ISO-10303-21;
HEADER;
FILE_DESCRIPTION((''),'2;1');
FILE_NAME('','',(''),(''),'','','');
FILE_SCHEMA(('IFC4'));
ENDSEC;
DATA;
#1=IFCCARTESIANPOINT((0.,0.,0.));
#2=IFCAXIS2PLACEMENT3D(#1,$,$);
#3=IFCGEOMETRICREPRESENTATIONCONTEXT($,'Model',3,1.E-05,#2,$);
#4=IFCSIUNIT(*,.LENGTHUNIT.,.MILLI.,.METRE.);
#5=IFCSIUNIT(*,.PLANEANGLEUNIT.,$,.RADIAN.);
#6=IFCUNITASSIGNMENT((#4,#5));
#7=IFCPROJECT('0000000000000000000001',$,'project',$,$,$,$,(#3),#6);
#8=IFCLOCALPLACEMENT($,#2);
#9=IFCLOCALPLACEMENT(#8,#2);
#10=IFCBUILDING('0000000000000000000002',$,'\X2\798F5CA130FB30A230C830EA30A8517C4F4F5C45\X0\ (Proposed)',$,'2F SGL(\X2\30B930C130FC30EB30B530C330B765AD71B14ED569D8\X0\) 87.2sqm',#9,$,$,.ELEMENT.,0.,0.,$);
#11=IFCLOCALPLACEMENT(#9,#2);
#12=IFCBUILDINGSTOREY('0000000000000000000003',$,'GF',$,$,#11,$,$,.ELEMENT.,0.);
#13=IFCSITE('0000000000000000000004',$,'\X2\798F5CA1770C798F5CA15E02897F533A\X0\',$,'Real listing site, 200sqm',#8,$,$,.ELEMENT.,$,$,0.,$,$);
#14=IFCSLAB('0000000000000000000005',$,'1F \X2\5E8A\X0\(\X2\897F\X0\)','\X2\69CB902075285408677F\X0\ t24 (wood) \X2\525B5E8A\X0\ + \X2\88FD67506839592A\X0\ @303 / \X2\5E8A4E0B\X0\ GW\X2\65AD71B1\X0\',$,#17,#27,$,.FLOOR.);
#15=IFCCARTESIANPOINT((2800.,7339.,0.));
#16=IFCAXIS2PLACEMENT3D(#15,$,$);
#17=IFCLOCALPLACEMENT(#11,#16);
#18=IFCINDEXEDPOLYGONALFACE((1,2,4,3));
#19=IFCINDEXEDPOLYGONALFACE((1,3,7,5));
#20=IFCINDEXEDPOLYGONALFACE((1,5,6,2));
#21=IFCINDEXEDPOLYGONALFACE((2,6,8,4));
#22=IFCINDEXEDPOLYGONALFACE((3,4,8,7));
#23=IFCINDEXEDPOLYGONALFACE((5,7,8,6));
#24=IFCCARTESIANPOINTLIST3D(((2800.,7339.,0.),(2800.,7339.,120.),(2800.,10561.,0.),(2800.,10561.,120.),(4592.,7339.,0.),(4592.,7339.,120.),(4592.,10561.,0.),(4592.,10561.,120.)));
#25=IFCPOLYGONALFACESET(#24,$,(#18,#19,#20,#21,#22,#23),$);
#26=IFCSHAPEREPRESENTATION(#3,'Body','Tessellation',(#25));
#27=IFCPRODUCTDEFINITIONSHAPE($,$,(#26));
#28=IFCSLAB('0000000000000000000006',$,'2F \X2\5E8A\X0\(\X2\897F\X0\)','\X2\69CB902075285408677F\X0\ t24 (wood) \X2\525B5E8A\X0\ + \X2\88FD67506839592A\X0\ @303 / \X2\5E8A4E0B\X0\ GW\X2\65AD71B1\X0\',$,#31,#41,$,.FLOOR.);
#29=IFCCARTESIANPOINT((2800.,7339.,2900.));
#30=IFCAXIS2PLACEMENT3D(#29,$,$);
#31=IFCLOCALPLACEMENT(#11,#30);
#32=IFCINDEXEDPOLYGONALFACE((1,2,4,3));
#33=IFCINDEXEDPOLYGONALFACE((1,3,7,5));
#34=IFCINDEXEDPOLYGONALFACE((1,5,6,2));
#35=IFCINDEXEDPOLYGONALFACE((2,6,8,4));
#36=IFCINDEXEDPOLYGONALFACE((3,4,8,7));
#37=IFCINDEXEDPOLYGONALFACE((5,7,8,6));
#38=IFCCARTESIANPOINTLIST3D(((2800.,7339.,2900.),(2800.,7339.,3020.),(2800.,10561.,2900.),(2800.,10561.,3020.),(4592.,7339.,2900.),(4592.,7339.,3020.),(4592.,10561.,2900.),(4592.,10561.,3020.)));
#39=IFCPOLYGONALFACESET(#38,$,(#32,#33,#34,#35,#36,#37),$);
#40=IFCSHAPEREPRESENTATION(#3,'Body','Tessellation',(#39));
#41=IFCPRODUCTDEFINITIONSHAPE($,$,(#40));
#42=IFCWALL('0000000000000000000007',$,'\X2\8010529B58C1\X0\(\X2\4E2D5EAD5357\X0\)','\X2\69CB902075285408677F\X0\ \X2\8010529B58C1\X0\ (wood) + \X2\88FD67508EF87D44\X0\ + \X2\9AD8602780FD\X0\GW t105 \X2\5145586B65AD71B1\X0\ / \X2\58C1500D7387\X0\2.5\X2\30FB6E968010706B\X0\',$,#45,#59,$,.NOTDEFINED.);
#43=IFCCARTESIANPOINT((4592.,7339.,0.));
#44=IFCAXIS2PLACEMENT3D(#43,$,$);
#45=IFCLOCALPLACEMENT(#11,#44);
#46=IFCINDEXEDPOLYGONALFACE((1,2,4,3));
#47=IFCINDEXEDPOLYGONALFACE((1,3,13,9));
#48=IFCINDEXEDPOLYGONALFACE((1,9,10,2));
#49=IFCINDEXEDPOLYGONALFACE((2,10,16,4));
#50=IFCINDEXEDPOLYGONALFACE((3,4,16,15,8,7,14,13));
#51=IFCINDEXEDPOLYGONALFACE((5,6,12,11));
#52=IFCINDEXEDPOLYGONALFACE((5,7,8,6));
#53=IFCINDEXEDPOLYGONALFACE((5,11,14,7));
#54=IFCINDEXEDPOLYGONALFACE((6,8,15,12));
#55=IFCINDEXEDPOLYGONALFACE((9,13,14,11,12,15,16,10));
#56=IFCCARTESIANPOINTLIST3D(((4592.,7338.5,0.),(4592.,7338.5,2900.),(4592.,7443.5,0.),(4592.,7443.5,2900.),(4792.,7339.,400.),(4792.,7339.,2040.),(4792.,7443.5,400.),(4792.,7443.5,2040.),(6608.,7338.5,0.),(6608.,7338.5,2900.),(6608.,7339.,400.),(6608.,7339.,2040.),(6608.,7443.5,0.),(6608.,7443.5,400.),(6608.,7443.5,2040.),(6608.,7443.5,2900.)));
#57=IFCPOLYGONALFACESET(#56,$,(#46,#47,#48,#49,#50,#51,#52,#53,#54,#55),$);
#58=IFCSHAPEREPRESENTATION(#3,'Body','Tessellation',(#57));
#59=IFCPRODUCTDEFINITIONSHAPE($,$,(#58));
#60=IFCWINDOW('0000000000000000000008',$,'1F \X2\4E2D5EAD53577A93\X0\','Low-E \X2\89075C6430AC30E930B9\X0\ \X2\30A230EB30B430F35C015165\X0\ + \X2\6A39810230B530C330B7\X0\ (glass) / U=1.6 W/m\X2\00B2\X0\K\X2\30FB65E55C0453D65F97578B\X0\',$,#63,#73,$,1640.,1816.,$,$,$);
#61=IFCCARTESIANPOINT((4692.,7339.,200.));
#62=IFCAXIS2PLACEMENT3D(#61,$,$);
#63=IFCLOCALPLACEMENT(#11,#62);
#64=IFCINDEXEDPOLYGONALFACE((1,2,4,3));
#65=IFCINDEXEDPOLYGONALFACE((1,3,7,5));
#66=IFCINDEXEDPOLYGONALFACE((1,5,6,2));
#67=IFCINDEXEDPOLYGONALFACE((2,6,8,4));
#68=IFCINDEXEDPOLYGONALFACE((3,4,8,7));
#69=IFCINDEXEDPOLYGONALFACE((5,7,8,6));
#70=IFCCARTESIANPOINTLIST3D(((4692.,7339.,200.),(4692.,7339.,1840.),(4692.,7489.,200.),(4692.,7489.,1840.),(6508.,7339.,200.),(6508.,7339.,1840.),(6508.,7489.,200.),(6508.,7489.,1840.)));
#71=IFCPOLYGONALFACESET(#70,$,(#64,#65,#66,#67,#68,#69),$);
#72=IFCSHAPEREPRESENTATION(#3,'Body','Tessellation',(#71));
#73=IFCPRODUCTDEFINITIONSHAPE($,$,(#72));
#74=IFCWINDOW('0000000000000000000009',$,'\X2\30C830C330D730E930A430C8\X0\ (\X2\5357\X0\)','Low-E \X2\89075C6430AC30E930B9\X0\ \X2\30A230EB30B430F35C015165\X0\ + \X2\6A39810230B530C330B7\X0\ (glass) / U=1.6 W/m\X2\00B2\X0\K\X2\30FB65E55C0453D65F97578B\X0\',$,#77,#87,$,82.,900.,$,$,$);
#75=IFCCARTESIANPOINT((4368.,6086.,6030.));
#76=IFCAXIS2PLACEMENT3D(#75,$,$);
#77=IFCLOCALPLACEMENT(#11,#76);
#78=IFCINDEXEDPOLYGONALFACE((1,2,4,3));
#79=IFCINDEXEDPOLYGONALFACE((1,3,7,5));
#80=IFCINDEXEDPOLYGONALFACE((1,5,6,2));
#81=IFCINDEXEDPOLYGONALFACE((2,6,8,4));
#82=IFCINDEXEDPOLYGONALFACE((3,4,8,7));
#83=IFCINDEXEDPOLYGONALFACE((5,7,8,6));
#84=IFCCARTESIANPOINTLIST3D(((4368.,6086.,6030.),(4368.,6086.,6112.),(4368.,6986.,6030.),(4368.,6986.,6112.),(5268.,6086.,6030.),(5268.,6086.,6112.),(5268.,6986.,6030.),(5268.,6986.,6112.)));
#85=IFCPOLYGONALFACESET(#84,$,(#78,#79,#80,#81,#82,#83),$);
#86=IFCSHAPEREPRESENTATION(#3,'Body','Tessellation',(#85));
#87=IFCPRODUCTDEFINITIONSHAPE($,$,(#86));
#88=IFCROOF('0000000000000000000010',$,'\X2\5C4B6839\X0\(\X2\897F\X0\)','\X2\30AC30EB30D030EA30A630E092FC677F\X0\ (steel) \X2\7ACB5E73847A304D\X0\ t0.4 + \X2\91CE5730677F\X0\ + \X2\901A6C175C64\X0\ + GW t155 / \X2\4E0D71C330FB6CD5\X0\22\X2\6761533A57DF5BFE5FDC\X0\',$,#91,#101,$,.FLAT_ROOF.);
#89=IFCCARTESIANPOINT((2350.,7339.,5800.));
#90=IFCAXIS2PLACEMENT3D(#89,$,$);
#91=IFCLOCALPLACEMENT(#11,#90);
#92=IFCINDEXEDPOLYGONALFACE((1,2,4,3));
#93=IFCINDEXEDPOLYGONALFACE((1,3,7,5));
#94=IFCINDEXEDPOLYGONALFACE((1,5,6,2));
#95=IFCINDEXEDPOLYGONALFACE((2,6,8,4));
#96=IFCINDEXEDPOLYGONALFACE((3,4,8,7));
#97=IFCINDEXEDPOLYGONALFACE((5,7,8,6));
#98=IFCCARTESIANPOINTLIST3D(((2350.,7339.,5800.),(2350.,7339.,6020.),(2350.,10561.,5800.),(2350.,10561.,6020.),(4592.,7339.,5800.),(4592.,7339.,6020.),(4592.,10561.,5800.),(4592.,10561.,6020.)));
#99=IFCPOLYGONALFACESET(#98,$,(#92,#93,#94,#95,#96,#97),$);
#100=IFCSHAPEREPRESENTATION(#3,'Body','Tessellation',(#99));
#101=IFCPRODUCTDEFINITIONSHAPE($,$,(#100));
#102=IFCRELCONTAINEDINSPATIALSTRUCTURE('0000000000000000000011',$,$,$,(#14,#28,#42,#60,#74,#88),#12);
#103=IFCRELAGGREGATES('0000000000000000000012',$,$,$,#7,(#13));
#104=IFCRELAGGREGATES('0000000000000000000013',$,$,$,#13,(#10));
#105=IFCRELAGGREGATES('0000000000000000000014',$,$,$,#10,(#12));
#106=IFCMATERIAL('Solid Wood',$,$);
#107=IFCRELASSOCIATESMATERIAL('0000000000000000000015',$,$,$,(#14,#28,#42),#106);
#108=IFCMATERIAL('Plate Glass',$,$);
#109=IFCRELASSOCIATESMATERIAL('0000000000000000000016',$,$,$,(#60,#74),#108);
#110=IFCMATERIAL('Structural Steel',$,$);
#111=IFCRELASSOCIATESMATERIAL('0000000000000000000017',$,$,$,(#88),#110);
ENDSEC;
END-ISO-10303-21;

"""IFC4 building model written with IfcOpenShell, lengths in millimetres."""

from ifc_helpers import new_model, si_unit, frame, frame_2d, origin, place, context, project, spatial, rectangle, extrude, material, element, fill, save


model = new_model("IFC4")

# Units and contexts
model_context = context("Model", 3, precision=1e-05, world=origin())
ifc_project = project(units=[si_unit("LENGTHUNIT", "METRE", prefix="MILLI"), si_unit("PLANEANGLEUNIT", "RADIAN")], contexts=[model_context])

# Site, building, storey
site_placement = place(None, origin())
site = spatial("IfcSite", under=ifc_project, at=site_placement, Name="福岡県福岡市西区", ObjectType="Real listing site, 200sqm", CompositionType="ELEMENT", RefElevation=0.0)
building_placement = place(site_placement, origin())
building = spatial("IfcBuilding", under=site, at=building_placement, Name="福岡・アトリエ兼住居 (Proposed)", ObjectType="2F SGL(スチールサッシ断熱仕様) 87.2sqm", CompositionType="ELEMENT", ElevationOfRefHeight=0.0, ElevationOfTerrain=0.0)
storey_placement = place(building_placement, origin())
storey = spatial("IfcBuildingStorey", under=building, at=storey_placement, Name="GF", CompositionType="ELEMENT", Elevation=0.0)

# Shared definitions
ifc_material_1 = material(Name="Solid Wood")

# Slabs
slab_1_placement = place(storey_placement, frame((2800.0, 7339.0, 0.0)))
element("IfcSlab", 1, at=slab_1_placement, inside=storey, material=ifc_material_1, Name="1F 床(西)", Description="構造用合板 t24 (wood) 剛床 + 製材根太 @303 / 床下 GW断熱", PredefinedType="FLOOR", context=model_context, shape_type="SweptSolid", body=[
    extrude(rectangle(XDim=1792.0, YDim=3222.0, at=frame_2d((896.0, 1611.0))), frame((2800.0, 7339.0, 0.0)), (0.0, 0.0, 1.0), 120.0),
])
slab_2_placement = place(storey_placement, frame((2800.0, 7339.0, 2900.0)))
element("IfcSlab", 2, at=slab_2_placement, inside=storey, material=ifc_material_1, Name="2F 床(西)", Description="構造用合板 t24 (wood) 剛床 + 製材根太 @303 / 床下 GW断熱", PredefinedType="FLOOR", context=model_context, shape_type="SweptSolid", body=[
    extrude(rectangle(XDim=1792.0, YDim=3222.0, at=frame_2d((896.0, 1611.0))), frame((2800.0, 7339.0, 2900.0)), (0.0, 0.0, 1.0), 120.0),
])

# Wall, opening, window
wall_placement = place(storey_placement, frame((4592.0, 7339.0, 0.0)))
wall = element("IfcWall", 3, at=wall_placement, inside=storey, material=ifc_material_1, Name="耐力壁(中庭南)", Description="構造用合板 耐力壁 (wood) + 製材軸組 + 高性能GW t105 充填断熱 / 壁倍率2.5・準耐火", PredefinedType="NOTDEFINED", context=model_context, shape_type="SweptSolid", body=[
    extrude(rectangle(XDim=2016.0, YDim=105.0, at=frame_2d((1008.0, 52.0))), frame((4592.0, 7339.0, 0.0)), (0.0, 0.0, 1.0), 2900.0),
])
opening_placement = place(storey_placement, frame((4692.0, 7339.0, 200.0)))
opening = element("IfcOpeningElement", 4, at=opening_placement, cuts=wall, PredefinedType="NOTDEFINED", context=model_context, shape_type="SweptSolid", body=[
    extrude(rectangle(XDim=1816.0, YDim=150.0, at=frame_2d((908.0, 75.0))), frame((4692.0, 7339.0, 200.0)), (0.0, 0.0, 1.0), 1640.0),
])
ifc_material_2 = material(Name="Plate Glass")
window_1_placement = place(storey_placement, frame((4692.0, 7339.0, 200.0)))
window_1 = element("IfcWindow", 5, at=window_1_placement, inside=storey, material=ifc_material_2, Name="1F 中庭南窓", Description="Low-E 複層ガラス アルゴン封入 + 樹脂サッシ (glass) / U=1.6 W/m²K・日射取得型", OverallHeight=1640.0, OverallWidth=1816.0, context=model_context, shape_type="SweptSolid", body=[
    extrude(rectangle(XDim=1816.0, YDim=150.0, at=frame_2d((908.0, 75.0))), frame((4692.0, 7339.0, 200.0)), (0.0, 0.0, 1.0), 1640.0),
])
fill(opening, window_1)

# Window
window_2_placement = place(storey_placement, frame((4368.0, 6086.0, 6030.0)))
element("IfcWindow", 6, at=window_2_placement, inside=storey, material=ifc_material_2, Name="トップライト (南)", Description="Low-E 複層ガラス アルゴン封入 + 樹脂サッシ (glass) / U=1.6 W/m²K・日射取得型", OverallHeight=82.0, OverallWidth=900.0, context=model_context, shape_type="SweptSolid", body=[
    extrude(rectangle(XDim=900.0, YDim=900.0, at=frame_2d((450.0, 450.0))), frame((4368.0, 6086.0, 6030.0)), (0.0, 0.0, 1.0), 82.0),
])

# Roof
ifc_material_3 = material(Name="Structural Steel")
for number, where, name in (
    (7, (2350.0, 7339.0, 5800.0), "屋根(西)"),
):
    element("IfcRoof", number, at=place(storey_placement, frame(where)), inside=storey, material=ifc_material_3, Name=name, Description="ガルバリウム鋼板 (steel) 立平葺き t0.4 + 野地板 + 通気層 + GW t155 / 不燃・法22条区域対応", PredefinedType="FLAT_ROOF", context=model_context, shape_type="SweptSolid", body=[
        extrude(rectangle(XDim=2242.0, YDim=3222.0, at=frame_2d((1121.0, 1611.0))), frame((2350.0, 7339.0, 5800.0)), (0.0, 0.0, 1.0), 220.0),
    ])

save(model, "model.ifc")
